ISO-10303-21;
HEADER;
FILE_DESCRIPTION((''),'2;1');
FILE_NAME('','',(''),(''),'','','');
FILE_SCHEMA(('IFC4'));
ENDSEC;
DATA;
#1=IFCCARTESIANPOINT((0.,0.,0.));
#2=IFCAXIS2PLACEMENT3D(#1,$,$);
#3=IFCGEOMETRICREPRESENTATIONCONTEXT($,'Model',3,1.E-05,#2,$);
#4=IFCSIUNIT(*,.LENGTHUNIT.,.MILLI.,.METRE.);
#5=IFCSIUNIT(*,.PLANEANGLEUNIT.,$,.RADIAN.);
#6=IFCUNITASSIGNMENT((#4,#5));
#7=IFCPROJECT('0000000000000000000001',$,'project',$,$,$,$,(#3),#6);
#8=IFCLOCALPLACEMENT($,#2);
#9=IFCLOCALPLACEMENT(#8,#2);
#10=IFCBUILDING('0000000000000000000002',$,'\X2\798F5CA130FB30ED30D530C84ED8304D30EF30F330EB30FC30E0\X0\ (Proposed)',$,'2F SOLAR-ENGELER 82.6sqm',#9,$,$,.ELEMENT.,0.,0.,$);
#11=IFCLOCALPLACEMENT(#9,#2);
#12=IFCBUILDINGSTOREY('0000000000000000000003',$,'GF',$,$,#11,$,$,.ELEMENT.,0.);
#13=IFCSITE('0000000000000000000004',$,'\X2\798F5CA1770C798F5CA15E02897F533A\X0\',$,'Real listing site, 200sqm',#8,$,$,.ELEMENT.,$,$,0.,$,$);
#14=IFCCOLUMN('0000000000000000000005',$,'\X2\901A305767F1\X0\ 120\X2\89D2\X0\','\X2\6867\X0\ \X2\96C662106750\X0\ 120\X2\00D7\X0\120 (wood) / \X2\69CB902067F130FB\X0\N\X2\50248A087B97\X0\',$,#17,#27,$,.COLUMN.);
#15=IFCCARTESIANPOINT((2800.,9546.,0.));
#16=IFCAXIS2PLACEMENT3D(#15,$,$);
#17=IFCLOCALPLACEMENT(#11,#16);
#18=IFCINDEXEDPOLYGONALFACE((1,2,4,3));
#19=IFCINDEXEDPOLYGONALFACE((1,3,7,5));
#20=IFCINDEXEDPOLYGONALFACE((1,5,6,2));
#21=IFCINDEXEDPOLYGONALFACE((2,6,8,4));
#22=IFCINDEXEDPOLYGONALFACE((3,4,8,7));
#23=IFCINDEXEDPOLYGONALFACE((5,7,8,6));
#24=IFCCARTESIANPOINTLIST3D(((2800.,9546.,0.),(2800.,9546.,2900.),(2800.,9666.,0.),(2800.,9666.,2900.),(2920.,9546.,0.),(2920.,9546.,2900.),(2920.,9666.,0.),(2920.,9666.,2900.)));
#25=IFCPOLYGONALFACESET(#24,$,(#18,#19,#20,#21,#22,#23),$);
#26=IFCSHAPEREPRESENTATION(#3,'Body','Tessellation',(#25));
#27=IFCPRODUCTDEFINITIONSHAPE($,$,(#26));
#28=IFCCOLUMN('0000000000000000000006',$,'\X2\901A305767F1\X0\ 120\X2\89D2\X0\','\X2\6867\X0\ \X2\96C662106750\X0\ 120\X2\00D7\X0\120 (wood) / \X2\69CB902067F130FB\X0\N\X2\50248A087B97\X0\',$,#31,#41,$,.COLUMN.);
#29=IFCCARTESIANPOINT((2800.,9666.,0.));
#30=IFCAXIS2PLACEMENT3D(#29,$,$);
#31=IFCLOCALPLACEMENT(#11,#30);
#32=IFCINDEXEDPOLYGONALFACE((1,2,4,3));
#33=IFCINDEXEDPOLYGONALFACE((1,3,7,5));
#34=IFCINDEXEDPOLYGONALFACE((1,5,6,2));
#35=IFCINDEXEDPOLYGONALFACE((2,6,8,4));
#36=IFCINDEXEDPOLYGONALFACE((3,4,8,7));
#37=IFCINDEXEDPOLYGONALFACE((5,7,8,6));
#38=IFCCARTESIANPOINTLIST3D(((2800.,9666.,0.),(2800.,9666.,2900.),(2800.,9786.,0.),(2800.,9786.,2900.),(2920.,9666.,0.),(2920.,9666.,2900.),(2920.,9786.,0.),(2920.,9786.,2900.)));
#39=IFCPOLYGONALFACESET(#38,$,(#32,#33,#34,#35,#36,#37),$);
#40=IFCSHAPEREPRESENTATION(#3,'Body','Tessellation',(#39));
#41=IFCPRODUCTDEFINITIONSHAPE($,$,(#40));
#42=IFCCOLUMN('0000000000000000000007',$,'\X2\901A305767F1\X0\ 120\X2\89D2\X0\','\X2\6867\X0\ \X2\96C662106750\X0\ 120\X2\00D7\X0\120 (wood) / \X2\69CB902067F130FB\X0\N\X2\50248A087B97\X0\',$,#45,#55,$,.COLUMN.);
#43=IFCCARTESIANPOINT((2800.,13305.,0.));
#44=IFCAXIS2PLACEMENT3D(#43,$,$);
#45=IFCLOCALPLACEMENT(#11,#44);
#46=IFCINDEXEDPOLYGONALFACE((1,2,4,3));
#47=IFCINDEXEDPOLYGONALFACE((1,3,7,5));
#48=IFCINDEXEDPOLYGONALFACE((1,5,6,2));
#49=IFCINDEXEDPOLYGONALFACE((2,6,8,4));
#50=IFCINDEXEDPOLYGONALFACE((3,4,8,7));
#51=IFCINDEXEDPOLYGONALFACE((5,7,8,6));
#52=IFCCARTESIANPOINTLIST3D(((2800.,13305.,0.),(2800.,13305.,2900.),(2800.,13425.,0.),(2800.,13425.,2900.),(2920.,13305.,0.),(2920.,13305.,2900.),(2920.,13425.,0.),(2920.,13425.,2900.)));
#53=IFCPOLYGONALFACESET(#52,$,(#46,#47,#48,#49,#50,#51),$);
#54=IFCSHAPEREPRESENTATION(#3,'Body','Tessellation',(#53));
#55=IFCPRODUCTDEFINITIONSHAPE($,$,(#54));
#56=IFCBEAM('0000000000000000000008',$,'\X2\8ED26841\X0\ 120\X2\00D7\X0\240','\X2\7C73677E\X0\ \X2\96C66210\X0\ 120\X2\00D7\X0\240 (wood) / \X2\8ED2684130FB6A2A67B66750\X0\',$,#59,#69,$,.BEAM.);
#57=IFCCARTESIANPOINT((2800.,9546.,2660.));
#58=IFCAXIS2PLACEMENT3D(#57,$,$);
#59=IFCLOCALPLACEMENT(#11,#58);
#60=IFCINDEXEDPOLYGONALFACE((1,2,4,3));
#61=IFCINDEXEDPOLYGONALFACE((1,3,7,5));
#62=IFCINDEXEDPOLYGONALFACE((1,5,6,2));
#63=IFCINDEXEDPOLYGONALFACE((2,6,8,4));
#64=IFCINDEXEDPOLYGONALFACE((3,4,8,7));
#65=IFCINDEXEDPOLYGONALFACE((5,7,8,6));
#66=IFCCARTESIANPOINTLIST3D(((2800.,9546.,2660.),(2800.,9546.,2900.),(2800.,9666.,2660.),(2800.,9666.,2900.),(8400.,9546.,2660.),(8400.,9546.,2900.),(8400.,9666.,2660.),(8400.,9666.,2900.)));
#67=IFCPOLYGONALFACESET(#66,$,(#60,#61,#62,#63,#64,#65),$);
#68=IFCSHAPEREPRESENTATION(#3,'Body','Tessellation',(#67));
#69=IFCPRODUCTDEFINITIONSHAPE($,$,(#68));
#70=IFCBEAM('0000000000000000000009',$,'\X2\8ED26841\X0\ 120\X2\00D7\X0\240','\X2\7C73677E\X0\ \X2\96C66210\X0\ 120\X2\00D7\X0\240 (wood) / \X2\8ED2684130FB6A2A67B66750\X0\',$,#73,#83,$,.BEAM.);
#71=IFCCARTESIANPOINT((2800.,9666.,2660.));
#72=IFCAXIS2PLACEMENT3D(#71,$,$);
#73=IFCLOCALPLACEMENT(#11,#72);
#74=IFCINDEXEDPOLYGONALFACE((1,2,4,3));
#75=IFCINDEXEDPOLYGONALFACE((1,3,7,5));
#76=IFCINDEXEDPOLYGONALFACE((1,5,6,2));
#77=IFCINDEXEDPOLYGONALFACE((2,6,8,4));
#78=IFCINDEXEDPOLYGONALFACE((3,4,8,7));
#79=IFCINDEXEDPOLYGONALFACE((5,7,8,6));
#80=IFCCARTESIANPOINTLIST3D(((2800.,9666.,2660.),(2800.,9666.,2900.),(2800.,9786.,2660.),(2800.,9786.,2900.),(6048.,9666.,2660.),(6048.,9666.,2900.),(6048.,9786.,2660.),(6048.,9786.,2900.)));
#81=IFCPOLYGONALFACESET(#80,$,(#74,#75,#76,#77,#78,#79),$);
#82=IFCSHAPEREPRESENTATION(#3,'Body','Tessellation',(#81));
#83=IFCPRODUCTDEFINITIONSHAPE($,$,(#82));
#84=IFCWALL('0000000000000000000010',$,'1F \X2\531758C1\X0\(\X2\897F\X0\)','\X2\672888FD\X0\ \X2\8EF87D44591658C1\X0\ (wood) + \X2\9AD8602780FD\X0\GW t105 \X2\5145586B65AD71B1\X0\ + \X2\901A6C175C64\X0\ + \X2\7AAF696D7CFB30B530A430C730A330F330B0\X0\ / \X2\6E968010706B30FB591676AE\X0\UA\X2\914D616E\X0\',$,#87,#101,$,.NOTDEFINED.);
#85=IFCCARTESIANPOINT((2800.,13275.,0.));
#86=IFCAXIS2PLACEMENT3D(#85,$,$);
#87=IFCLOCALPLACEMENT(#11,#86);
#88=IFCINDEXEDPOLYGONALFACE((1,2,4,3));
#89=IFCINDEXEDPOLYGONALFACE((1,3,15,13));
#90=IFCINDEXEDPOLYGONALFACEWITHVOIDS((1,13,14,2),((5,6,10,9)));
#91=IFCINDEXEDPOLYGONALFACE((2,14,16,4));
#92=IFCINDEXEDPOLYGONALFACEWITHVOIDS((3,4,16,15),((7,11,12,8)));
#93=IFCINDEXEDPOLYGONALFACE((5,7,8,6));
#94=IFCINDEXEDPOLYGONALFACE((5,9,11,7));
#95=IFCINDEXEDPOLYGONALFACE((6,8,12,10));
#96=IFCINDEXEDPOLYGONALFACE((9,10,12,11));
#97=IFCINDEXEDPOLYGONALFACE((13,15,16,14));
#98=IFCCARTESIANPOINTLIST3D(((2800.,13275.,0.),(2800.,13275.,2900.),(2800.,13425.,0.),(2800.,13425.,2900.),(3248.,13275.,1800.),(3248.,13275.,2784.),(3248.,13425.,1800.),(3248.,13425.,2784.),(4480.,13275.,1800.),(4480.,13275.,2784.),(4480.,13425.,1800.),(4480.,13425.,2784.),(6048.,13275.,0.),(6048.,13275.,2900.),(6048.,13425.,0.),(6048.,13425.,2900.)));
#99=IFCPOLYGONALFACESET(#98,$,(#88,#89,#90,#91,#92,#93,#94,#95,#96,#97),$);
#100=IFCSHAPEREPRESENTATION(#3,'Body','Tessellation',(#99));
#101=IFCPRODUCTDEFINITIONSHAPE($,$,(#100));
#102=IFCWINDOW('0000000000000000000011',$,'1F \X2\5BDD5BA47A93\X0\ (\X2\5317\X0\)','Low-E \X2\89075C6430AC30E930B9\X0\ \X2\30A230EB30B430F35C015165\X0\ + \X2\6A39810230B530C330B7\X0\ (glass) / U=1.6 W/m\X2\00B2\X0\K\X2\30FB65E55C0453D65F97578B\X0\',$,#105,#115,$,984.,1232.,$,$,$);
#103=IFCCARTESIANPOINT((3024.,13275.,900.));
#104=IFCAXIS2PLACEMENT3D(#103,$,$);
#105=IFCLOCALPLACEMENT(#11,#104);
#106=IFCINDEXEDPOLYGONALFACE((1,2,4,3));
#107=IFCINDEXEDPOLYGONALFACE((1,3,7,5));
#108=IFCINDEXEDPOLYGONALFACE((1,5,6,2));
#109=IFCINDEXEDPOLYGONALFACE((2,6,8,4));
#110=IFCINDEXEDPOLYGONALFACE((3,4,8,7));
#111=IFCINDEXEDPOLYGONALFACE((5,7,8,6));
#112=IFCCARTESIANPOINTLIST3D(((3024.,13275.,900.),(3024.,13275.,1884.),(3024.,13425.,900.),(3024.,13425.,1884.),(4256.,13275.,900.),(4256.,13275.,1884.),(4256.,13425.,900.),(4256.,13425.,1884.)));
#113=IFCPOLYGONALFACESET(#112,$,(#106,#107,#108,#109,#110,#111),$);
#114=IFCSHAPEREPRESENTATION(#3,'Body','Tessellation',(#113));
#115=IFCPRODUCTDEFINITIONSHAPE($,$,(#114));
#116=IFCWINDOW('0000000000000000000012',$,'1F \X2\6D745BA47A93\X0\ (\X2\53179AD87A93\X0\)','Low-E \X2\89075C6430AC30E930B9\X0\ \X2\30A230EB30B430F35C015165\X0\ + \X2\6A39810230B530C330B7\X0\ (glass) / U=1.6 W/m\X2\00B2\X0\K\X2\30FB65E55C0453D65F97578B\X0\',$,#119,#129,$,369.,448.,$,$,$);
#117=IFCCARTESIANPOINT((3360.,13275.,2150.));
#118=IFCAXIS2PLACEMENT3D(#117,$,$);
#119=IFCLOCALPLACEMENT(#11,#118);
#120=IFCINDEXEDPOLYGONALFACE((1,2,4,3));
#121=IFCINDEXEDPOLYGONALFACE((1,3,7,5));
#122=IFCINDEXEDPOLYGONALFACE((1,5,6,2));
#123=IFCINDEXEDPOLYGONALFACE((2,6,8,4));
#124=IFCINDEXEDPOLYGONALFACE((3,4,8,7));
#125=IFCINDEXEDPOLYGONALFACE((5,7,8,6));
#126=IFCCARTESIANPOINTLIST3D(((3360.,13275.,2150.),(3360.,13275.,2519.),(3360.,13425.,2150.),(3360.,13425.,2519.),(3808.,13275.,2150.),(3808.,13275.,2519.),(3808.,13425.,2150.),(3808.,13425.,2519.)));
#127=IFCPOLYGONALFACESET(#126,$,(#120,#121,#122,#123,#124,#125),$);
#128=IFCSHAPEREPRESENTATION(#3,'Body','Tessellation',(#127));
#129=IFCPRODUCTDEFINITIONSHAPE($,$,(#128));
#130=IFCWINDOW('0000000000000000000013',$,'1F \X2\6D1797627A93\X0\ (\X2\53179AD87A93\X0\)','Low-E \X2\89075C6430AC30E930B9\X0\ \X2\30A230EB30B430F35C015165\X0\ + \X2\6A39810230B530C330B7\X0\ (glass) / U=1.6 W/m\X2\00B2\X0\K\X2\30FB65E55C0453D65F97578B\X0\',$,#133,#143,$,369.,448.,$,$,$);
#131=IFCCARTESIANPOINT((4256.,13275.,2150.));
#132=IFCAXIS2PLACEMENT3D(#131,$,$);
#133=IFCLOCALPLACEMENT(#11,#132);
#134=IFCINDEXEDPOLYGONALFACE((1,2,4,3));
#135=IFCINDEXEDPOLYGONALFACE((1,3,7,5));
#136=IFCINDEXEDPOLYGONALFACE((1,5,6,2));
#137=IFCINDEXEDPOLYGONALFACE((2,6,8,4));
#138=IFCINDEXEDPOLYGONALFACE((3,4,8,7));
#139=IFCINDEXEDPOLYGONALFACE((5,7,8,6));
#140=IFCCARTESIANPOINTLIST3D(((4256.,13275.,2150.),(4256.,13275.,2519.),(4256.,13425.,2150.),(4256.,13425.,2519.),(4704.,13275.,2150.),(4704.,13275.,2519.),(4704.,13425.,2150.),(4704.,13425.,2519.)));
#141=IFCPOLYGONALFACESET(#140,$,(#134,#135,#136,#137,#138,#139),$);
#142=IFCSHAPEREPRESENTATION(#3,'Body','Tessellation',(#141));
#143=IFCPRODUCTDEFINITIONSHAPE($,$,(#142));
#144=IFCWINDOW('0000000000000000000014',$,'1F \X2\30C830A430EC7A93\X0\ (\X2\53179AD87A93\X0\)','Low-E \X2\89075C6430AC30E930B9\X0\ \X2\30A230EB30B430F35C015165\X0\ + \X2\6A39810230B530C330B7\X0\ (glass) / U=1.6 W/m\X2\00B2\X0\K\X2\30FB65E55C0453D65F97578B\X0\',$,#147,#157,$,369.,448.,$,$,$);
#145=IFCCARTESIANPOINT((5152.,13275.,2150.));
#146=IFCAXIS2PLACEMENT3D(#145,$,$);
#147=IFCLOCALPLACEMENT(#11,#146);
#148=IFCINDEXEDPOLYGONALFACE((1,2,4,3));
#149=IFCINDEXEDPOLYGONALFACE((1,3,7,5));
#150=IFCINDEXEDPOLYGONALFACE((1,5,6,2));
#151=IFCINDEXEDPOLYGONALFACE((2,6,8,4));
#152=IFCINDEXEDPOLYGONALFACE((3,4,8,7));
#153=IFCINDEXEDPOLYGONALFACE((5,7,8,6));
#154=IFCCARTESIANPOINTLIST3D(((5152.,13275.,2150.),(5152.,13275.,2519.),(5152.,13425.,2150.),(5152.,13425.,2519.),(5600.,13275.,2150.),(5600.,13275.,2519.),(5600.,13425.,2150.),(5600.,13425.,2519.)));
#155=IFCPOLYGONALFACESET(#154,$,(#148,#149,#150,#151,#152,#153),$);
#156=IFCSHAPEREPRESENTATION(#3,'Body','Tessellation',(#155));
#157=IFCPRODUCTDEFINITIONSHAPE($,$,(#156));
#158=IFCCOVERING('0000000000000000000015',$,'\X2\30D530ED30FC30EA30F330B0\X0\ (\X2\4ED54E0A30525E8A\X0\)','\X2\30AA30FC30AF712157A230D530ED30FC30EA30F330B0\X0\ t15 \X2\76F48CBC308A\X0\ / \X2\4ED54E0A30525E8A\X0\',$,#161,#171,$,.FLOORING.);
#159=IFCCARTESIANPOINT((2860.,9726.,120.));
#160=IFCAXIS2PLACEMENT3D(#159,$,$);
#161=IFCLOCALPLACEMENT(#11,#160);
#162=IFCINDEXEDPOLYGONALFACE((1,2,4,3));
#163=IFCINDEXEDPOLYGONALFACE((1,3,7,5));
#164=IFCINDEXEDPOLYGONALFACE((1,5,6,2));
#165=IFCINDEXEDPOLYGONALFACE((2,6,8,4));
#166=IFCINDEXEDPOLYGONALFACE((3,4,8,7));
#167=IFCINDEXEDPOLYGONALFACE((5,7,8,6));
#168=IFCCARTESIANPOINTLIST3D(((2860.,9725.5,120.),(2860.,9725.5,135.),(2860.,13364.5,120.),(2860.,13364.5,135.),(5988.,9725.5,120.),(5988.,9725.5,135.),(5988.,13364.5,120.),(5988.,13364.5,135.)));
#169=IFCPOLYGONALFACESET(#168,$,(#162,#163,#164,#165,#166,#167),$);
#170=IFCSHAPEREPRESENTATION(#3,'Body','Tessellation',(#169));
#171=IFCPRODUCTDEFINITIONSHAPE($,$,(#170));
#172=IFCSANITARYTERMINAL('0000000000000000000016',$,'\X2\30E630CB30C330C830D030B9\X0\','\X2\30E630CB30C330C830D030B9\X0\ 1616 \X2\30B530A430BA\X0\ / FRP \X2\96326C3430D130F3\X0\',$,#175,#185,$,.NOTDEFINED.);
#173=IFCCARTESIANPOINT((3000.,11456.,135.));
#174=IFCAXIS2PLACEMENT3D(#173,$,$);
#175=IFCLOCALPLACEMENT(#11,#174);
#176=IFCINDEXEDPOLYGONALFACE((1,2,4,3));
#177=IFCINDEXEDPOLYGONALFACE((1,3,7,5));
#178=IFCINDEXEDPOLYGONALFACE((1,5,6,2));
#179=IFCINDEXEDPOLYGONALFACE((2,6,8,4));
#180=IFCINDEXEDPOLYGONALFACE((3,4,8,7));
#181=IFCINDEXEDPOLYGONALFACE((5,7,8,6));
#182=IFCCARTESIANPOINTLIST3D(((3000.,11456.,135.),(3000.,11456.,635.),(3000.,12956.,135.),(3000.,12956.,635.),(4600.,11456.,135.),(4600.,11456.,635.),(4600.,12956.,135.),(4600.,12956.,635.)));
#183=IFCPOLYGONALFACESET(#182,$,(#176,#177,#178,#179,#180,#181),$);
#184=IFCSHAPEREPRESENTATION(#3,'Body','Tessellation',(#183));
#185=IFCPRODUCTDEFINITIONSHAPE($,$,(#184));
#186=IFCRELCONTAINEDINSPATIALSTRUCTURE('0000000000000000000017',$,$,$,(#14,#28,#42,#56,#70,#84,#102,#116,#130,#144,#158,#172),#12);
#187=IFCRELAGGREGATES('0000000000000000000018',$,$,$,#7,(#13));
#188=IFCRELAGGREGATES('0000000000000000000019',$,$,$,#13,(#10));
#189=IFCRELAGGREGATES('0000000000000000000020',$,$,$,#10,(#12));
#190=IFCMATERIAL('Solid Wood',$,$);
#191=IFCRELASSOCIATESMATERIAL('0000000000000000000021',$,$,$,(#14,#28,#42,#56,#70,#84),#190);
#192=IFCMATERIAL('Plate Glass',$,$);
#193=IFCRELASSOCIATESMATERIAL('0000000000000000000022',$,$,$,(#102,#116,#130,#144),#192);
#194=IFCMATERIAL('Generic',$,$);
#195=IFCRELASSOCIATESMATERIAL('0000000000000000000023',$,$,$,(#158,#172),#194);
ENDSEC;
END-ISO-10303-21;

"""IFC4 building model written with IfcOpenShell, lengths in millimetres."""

from ifc_helpers import new_model, si_unit, frame, frame_2d, origin, place, context, project, spatial, rectangle, extrude, material, element, fill, save


model = new_model("IFC4")

# Units and contexts
model_context = context("Model", 3, precision=1e-05, world=origin())
ifc_project = project(units=[si_unit("LENGTHUNIT", "METRE", prefix="MILLI"), si_unit("PLANEANGLEUNIT", "RADIAN")], contexts=[model_context])

# Site, building, storey
site_placement = place(None, origin())
site = spatial("IfcSite", under=ifc_project, at=site_placement, Name="福岡県福岡市西区", ObjectType="Real listing site, 200sqm", CompositionType="ELEMENT", RefElevation=0.0)
building_placement = place(site_placement, origin())
building = spatial("IfcBuilding", under=site, at=building_placement, Name="福岡・ロフト付きワンルーム (Proposed)", ObjectType="2F SOLAR-ENGELER 82.6sqm", CompositionType="ELEMENT", ElevationOfRefHeight=0.0, ElevationOfTerrain=0.0)
storey_placement = place(building_placement, origin())
storey = spatial("IfcBuildingStorey", under=building, at=storey_placement, Name="GF", CompositionType="ELEMENT", Elevation=0.0)

# Columns
ifc_material_1 = material(Name="Solid Wood")
column_1_placement = place(storey_placement, frame((2800.0, 9546.0, 0.0)))
element("IfcColumn", 1, at=column_1_placement, inside=storey, material=ifc_material_1, Name="通し柱 120角", Description="桧 集成材 120×120 (wood) / 構造柱・N値計算", PredefinedType="COLUMN", context=model_context, shape_type="SweptSolid", body=[
    extrude(rectangle(XDim=120.0, YDim=120.0, at=frame_2d((60.0, 60.0))), frame((2800.0, 9546.0, 0.0)), (0.0, 0.0, 1.0), 2900.0),
])
column_2_placement = place(storey_placement, frame((2800.0, 9666.0, 0.0)))
element("IfcColumn", 2, at=column_2_placement, inside=storey, material=ifc_material_1, Name="通し柱 120角", Description="桧 集成材 120×120 (wood) / 構造柱・N値計算", PredefinedType="COLUMN", context=model_context, shape_type="SweptSolid", body=[
    extrude(rectangle(XDim=120.0, YDim=120.0, at=frame_2d((60.0, 60.0))), frame((2800.0, 9666.0, 0.0)), (0.0, 0.0, 1.0), 2900.0),
])
column_3_placement = place(storey_placement, frame((2800.0, 13305.0, 0.0)))
element("IfcColumn", 3, at=column_3_placement, inside=storey, material=ifc_material_1, Name="通し柱 120角", Description="桧 集成材 120×120 (wood) / 構造柱・N値計算", PredefinedType="COLUMN", context=model_context, shape_type="SweptSolid", body=[
    extrude(rectangle(XDim=120.0, YDim=120.0, at=frame_2d((60.0, 60.0))), frame((2800.0, 13305.0, 0.0)), (0.0, 0.0, 1.0), 2900.0),
])

# Beams
beam_1_placement = place(storey_placement, frame((2800.0, 9546.0, 2660.0)))
element("IfcBeam", 4, at=beam_1_placement, inside=storey, material=ifc_material_1, Name="軒桁 120×240", Description="米松 集成 120×240 (wood) / 軒桁・横架材", PredefinedType="BEAM", context=model_context, shape_type="SweptSolid", body=[
    extrude(rectangle(XDim=5600.0, YDim=120.0, at=frame_2d((2800.0, 60.0))), frame((2800.0, 9546.0, 2660.0)), (0.0, 0.0, 1.0), 240.0),
])
beam_2_placement = place(storey_placement, frame((2800.0, 9666.0, 2660.0)))
element("IfcBeam", 5, at=beam_2_placement, inside=storey, material=ifc_material_1, Name="軒桁 120×240", Description="米松 集成 120×240 (wood) / 軒桁・横架材", PredefinedType="BEAM", context=model_context, shape_type="SweptSolid", body=[
    extrude(rectangle(XDim=3248.0, YDim=120.0, at=frame_2d((1624.0, 60.0))), frame((2800.0, 9666.0, 2660.0)), (0.0, 0.0, 1.0), 240.0),
])

# Wall, openings, windows
wall_1_placement = place(storey_placement, frame((2800.0, 13275.0, 0.0)))
wall_1 = element("IfcWall", 6, at=wall_1_placement, inside=storey, material=ifc_material_1, Name="1F 北壁(西)", Description="木製 軸組外壁 (wood) + 高性能GW t105 充填断熱 + 通気層 + 窯業系サイディング / 準耐火・外皮UA配慮", PredefinedType="NOTDEFINED", context=model_context, shape_type="SweptSolid", body=[
    extrude(rectangle(XDim=3248.0, YDim=150.0, at=frame_2d((1624.0, 75.0))), frame((2800.0, 13275.0, 0.0)), (0.0, 0.0, 1.0), 2900.0),
])
opening_1_placement = place(storey_placement, frame((3024.0, 13275.0, 900.0)))
opening_1 = element("IfcOpeningElement", 7, at=opening_1_placement, cuts=wall_1, PredefinedType="NOTDEFINED", context=model_context, shape_type="SweptSolid", body=[
    extrude(rectangle(XDim=1232.0, YDim=150.0, at=frame_2d((616.0, 75.0))), frame((3024.0, 13275.0, 900.0)), (0.0, 0.0, 1.0), 984.0),
])
opening_2_placement = place(storey_placement, frame((3360.0, 13275.0, 2150.0)))
opening_2 = element("IfcOpeningElement", 8, at=opening_2_placement, cuts=wall_1, PredefinedType="NOTDEFINED", context=model_context, shape_type="SweptSolid", body=[
    extrude(rectangle(XDim=448.0, YDim=150.0, at=frame_2d((224.0, 75.0))), frame((3360.0, 13275.0, 2150.0)), (0.0, 0.0, 1.0), 369.0),
])
opening_3_placement = place(storey_placement, frame((4256.0, 13275.0, 2150.0)))
opening_3 = element("IfcOpeningElement", 9, at=opening_3_placement, cuts=wall_1, PredefinedType="NOTDEFINED", context=model_context, shape_type="SweptSolid", body=[
    extrude(rectangle(XDim=448.0, YDim=150.0, at=frame_2d((224.0, 75.0))), frame((4256.0, 13275.0, 2150.0)), (0.0, 0.0, 1.0), 369.0),
])
opening_4_placement = place(storey_placement, frame((5152.0, 13275.0, 2150.0)))
opening_4 = element("IfcOpeningElement", 10, at=opening_4_placement, cuts=wall_1, PredefinedType="NOTDEFINED", context=model_context, shape_type="SweptSolid", body=[
    extrude(rectangle(XDim=448.0, YDim=150.0, at=frame_2d((224.0, 75.0))), frame((5152.0, 13275.0, 2150.0)), (0.0, 0.0, 1.0), 369.0),
])
ifc_material_2 = material(Name="Plate Glass")
window_1_placement = place(storey_placement, frame((3024.0, 13275.0, 900.0)))
window_1 = element("IfcWindow", 11, at=window_1_placement, inside=storey, material=ifc_material_2, Name="1F 寝室窓 (北)", Description="Low-E 複層ガラス アルゴン封入 + 樹脂サッシ (glass) / U=1.6 W/m²K・日射取得型", OverallHeight=984.0, OverallWidth=1232.0, context=model_context, shape_type="SweptSolid", body=[
    extrude(rectangle(XDim=1232.0, YDim=150.0, at=frame_2d((616.0, 75.0))), frame((3024.0, 13275.0, 900.0)), (0.0, 0.0, 1.0), 984.0),
])
fill(opening_1, window_1)
window_2_placement = place(storey_placement, frame((3360.0, 13275.0, 2150.0)))
window_2 = element("IfcWindow", 12, at=window_2_placement, inside=storey, material=ifc_material_2, Name="1F 浴室窓 (北高窓)", Description="Low-E 複層ガラス アルゴン封入 + 樹脂サッシ (glass) / U=1.6 W/m²K・日射取得型", OverallHeight=369.0, OverallWidth=448.0, context=model_context, shape_type="SweptSolid", body=[
    extrude(rectangle(XDim=448.0, YDim=150.0, at=frame_2d((224.0, 75.0))), frame((3360.0, 13275.0, 2150.0)), (0.0, 0.0, 1.0), 369.0),
])
fill(opening_2, window_2)
window_3_placement = place(storey_placement, frame((4256.0, 13275.0, 2150.0)))
window_3 = element("IfcWindow", 13, at=window_3_placement, inside=storey, material=ifc_material_2, Name="1F 洗面窓 (北高窓)", Description="Low-E 複層ガラス アルゴン封入 + 樹脂サッシ (glass) / U=1.6 W/m²K・日射取得型", OverallHeight=369.0, OverallWidth=448.0, context=model_context, shape_type="SweptSolid", body=[
    extrude(rectangle(XDim=448.0, YDim=150.0, at=frame_2d((224.0, 75.0))), frame((4256.0, 13275.0, 2150.0)), (0.0, 0.0, 1.0), 369.0),
])
fill(opening_3, window_3)
window_4_placement = place(storey_placement, frame((5152.0, 13275.0, 2150.0)))
window_4 = element("IfcWindow", 14, at=window_4_placement, inside=storey, material=ifc_material_2, Name="1F トイレ窓 (北高窓)", Description="Low-E 複層ガラス アルゴン封入 + 樹脂サッシ (glass) / U=1.6 W/m²K・日射取得型", OverallHeight=369.0, OverallWidth=448.0, context=model_context, shape_type="SweptSolid", body=[
    extrude(rectangle(XDim=448.0, YDim=150.0, at=frame_2d((224.0, 75.0))), frame((5152.0, 13275.0, 2150.0)), (0.0, 0.0, 1.0), 369.0),
])
fill(opening_4, window_4)

# Covering
ifc_material_3 = material(Name="Generic")
covering_placement = place(storey_placement, frame((2860.0, 9726.0, 120.0)))
element("IfcCovering", 15, at=covering_placement, inside=storey, material=ifc_material_3, Name="フローリング (仕上げ床)", Description="オーク無垢フローリング t15 直貼り / 仕上げ床", PredefinedType="FLOORING", context=model_context, shape_type="SweptSolid", body=[
    extrude(rectangle(XDim=3128.0, YDim=3639.0, at=frame_2d((1564.0, 1819.0))), frame((2860.0, 9726.0, 120.0)), (0.0, 0.0, 1.0), 15.0),
])

# Sanitary terminal
sanitary_terminal_placement = place(storey_placement, frame((3000.0, 11456.0, 135.0)))
element("IfcSanitaryTerminal", 16, at=sanitary_terminal_placement, inside=storey, material=ifc_material_3, Name="ユニットバス", Description="ユニットバス 1616 サイズ / FRP 防水パン", PredefinedType="NOTDEFINED", context=model_context, shape_type="SweptSolid", body=[
    extrude(rectangle(XDim=1600.0, YDim=1500.0, at=frame_2d((800.0, 750.0))), frame((3000.0, 11456.0, 135.0)), (0.0, 0.0, 1.0), 500.0),
])

save(model, "model.ifc")
